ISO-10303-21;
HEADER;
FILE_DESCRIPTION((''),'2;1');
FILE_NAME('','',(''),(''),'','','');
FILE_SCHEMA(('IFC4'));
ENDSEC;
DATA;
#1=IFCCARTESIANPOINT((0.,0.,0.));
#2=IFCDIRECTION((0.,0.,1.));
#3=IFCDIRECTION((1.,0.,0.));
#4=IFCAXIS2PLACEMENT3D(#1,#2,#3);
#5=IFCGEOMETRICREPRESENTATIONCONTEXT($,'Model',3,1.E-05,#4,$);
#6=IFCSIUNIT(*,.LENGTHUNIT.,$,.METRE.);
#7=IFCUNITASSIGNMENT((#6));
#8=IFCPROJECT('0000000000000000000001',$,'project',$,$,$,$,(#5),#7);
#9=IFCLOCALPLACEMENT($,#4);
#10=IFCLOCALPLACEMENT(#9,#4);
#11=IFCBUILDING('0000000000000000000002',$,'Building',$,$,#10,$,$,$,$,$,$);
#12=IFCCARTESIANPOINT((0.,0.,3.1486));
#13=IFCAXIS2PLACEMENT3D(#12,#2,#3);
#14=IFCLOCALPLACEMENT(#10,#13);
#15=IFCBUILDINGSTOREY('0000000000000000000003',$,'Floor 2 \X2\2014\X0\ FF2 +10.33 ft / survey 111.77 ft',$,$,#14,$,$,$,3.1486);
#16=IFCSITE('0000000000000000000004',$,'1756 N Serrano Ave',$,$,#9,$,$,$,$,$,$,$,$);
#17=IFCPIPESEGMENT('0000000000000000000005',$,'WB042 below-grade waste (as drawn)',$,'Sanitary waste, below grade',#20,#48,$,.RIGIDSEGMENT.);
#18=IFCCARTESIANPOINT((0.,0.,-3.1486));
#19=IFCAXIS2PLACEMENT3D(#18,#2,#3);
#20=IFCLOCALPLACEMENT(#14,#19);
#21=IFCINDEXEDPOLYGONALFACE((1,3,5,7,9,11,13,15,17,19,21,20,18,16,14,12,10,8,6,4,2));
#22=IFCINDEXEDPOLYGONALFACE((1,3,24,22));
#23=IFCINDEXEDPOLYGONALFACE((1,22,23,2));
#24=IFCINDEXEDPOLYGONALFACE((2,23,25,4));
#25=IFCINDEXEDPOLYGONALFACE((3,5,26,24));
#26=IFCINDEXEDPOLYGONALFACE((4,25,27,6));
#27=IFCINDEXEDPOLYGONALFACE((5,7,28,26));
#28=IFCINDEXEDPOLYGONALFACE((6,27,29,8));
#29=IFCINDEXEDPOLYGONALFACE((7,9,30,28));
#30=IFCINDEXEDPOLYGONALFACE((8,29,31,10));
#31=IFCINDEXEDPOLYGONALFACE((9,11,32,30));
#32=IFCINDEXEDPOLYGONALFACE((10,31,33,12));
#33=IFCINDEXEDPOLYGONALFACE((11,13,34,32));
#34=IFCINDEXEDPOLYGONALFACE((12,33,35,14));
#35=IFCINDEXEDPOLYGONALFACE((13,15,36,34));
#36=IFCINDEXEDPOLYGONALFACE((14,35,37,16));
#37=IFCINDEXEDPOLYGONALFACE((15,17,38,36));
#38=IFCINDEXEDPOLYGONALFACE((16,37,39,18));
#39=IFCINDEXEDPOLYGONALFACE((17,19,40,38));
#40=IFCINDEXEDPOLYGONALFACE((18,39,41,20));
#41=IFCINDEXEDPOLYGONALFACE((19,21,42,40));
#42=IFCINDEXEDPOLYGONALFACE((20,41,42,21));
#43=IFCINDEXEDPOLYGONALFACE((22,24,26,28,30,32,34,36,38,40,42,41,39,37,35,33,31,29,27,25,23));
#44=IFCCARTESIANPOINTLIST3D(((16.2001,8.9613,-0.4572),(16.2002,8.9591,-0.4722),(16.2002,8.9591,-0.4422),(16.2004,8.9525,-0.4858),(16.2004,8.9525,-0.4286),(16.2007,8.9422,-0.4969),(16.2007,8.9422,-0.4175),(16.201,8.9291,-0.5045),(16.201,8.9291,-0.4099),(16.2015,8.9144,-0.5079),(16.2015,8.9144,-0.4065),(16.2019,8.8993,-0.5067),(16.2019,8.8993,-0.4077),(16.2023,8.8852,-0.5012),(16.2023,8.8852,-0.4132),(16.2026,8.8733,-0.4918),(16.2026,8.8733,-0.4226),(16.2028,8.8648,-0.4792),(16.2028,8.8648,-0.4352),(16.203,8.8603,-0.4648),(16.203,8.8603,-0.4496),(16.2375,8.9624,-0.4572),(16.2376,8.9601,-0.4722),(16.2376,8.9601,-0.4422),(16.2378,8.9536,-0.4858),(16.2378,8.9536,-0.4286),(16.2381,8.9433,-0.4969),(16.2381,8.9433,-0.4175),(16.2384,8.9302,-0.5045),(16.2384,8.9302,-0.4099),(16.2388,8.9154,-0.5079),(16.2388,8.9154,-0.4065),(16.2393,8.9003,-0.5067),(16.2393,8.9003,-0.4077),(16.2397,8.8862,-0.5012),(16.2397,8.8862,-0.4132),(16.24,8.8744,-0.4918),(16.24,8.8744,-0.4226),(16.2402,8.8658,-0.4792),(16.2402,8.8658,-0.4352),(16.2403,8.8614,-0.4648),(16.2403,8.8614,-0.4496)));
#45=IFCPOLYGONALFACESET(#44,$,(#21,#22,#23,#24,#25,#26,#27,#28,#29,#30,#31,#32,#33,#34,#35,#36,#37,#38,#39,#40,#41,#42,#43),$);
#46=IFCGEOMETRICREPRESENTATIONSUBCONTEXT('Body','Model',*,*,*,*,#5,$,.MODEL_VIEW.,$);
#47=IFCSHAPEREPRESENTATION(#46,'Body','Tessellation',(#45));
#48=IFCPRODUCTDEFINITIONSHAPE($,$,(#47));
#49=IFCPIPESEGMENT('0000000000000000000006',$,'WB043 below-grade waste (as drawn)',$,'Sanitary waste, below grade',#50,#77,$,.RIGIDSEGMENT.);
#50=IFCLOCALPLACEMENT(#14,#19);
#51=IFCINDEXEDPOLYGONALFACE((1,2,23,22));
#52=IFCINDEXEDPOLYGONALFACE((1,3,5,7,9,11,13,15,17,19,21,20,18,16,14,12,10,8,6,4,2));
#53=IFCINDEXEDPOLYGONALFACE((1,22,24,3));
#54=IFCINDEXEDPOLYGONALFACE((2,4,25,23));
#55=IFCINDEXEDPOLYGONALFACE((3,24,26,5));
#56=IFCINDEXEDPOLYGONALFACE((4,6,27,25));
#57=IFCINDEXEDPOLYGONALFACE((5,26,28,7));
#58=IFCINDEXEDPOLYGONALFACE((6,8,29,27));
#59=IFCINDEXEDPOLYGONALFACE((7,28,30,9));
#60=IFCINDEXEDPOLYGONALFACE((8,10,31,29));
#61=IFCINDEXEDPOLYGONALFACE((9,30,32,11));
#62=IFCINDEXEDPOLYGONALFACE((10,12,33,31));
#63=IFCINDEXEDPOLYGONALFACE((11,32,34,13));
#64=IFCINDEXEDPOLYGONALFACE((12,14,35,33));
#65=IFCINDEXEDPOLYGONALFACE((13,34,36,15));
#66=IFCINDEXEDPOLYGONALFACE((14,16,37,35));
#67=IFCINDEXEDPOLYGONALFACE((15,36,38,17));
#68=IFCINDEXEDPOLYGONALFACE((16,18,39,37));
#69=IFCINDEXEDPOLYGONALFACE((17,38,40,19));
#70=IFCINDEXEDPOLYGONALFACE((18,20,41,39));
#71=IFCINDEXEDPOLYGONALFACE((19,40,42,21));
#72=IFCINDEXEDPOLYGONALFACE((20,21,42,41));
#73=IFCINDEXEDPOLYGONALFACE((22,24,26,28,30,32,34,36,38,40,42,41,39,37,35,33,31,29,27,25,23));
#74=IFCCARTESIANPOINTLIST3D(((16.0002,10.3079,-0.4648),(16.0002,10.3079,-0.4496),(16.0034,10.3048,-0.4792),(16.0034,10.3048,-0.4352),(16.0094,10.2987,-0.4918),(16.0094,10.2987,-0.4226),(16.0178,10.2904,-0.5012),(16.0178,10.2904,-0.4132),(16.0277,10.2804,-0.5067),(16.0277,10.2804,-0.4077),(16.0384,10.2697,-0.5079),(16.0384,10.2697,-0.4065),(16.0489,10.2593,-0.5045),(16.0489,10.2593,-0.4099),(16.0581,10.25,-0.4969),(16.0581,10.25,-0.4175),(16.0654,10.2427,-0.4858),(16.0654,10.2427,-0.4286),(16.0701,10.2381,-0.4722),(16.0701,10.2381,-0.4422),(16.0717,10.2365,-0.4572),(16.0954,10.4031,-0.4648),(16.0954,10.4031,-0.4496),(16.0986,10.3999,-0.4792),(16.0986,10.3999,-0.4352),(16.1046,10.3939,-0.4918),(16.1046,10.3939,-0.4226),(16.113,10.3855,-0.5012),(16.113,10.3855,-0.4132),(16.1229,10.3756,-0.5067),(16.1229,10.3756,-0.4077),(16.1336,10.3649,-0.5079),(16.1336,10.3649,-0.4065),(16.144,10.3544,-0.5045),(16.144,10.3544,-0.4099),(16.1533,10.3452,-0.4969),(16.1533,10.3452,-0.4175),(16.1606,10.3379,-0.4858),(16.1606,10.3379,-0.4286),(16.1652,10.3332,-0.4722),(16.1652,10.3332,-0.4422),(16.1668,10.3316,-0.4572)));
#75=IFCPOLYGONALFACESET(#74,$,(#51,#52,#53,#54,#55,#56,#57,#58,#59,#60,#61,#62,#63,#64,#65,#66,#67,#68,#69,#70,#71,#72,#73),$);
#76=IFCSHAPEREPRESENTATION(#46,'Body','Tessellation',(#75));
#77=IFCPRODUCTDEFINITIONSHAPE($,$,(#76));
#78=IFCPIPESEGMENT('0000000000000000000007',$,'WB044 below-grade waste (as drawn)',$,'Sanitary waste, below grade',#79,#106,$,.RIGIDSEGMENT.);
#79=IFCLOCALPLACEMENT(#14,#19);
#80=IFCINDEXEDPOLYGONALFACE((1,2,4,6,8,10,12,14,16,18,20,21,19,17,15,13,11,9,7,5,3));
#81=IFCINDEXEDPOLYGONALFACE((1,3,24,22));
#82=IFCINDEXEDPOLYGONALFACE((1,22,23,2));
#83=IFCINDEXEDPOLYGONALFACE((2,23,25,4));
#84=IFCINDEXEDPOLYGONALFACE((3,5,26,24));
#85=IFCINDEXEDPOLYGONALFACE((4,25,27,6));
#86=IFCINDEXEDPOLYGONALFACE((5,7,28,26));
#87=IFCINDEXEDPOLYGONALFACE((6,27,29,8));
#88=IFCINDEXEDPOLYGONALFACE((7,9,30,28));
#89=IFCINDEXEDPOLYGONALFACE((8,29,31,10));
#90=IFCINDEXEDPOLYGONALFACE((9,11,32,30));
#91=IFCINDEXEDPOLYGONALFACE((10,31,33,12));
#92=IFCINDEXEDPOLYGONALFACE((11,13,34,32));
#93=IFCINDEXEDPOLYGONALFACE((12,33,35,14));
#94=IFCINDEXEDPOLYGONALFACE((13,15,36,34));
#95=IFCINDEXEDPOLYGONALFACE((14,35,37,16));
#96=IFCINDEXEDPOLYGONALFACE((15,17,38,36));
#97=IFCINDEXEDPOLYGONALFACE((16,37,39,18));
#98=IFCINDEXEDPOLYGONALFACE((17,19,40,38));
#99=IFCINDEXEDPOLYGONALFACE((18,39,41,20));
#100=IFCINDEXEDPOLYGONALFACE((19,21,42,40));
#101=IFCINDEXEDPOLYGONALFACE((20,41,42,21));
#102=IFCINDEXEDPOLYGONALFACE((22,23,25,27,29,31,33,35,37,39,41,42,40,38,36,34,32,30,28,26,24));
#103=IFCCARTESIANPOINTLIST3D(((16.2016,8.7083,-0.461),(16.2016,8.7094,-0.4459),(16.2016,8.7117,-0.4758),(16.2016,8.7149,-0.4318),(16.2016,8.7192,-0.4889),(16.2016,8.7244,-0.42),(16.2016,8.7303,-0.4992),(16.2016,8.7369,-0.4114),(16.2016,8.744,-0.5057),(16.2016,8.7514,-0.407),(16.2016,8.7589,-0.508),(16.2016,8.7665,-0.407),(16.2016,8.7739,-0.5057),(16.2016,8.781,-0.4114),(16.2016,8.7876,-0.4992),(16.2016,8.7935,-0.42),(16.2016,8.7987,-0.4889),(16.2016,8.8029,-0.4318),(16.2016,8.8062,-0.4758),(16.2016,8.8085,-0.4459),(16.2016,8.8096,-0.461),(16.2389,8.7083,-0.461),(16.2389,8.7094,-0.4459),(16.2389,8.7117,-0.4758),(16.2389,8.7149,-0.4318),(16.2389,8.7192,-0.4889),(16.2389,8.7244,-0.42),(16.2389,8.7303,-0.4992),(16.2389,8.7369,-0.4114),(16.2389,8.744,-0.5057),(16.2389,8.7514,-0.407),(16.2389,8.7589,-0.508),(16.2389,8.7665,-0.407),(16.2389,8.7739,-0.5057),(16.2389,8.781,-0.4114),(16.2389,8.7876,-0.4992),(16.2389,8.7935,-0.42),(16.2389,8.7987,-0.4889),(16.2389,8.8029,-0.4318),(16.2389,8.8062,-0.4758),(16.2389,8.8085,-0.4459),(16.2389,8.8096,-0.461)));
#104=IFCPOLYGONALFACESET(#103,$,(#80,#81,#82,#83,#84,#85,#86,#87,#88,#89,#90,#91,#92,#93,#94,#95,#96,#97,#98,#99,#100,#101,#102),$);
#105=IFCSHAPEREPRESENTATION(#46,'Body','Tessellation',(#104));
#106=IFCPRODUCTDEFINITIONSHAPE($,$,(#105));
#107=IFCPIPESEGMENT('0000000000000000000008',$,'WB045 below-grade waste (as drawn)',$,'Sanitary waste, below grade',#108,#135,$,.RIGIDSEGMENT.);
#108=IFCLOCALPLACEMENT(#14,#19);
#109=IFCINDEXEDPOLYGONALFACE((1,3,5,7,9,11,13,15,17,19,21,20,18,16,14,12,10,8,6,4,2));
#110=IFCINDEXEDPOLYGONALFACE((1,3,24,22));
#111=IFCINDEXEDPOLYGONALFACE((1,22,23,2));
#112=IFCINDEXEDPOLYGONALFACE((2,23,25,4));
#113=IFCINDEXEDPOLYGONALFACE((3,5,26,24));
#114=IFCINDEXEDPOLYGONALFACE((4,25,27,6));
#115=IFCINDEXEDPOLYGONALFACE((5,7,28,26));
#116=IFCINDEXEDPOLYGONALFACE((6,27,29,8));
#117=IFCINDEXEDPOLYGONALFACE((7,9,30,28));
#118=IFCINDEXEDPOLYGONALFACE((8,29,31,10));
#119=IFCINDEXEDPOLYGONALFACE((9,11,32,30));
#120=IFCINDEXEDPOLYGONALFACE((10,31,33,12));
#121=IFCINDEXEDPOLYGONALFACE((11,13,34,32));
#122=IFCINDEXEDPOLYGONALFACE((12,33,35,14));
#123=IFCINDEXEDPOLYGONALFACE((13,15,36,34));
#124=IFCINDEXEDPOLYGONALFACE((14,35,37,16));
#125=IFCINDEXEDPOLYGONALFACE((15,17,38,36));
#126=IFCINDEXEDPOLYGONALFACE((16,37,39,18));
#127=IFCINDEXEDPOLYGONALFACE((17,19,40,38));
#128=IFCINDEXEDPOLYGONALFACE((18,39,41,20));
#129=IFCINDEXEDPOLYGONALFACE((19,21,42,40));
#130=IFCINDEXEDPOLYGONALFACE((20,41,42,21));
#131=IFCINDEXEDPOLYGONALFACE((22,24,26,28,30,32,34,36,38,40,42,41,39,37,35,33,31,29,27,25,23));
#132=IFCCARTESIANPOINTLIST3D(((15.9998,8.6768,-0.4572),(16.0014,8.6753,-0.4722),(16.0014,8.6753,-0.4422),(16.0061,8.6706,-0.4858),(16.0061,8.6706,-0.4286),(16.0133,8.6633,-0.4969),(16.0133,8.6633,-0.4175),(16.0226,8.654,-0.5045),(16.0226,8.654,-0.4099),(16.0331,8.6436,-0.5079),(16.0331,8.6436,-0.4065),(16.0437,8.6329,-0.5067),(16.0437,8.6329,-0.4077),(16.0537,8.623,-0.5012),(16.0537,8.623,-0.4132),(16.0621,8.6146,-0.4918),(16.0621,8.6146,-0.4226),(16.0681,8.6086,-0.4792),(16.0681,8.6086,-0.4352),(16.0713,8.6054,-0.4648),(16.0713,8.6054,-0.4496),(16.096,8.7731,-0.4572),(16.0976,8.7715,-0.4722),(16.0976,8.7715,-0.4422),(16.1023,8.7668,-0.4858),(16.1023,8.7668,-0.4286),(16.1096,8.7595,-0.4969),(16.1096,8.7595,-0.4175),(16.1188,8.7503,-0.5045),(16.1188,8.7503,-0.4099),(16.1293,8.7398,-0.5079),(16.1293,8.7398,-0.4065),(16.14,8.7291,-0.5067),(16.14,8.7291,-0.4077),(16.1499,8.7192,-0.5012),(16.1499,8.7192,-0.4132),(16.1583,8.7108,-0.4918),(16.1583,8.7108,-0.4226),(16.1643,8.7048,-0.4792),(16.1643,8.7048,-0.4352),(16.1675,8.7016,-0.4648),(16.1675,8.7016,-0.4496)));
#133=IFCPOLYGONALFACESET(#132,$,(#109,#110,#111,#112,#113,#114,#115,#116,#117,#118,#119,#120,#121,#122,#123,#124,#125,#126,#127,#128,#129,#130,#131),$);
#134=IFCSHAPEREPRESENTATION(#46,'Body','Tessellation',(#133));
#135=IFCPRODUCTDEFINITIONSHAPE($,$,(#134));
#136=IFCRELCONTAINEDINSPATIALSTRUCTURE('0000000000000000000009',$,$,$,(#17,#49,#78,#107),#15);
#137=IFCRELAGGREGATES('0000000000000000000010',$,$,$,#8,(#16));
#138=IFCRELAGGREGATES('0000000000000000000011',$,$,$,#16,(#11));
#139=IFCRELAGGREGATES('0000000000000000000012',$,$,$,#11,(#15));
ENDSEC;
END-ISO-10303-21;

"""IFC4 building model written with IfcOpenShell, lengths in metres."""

from ifc_helpers import new_model, entity, si_unit, frame, origin_with_axes, place, context, subcontext, project, spatial, element, save


model = new_model("IFC4")

# Units and contexts
model_context = context("Model", 3, precision=1e-05, world=origin_with_axes())
body_context = subcontext(model_context, "Body", "Model", "MODEL_VIEW")
ifc_project = project(units=[si_unit("LENGTHUNIT", "METRE")], contexts=[model_context])

# Site, building, storey
site_placement = place(None, origin_with_axes())
site = spatial("IfcSite", under=ifc_project, at=site_placement, Name="1756 N Serrano Ave")
building_placement = place(site_placement, origin_with_axes())
building = spatial("IfcBuilding", under=site, at=building_placement, Name="Building")
storey_placement = place(building_placement, frame((0.0, 0.0, 3.1486), z_axis=(0.0, 0.0, 1.0), x_axis=(1.0, 0.0, 0.0)))
storey = spatial("IfcBuildingStorey", under=building, at=storey_placement, Name="Floor 2 — FF2 +10.33 ft / survey 111.77 ft", Elevation=3.1486)

# Pipe segments
pipe_segment_1_placement = place(storey_placement, frame((0.0, 0.0, -3.1486), z_axis=(0.0, 0.0, 1.0), x_axis=(1.0, 0.0, 0.0)))
element("IfcPipeSegment", 1, at=pipe_segment_1_placement, inside=storey, Name="WB042 below-grade waste (as drawn)", ObjectType="Sanitary waste, below grade", PredefinedType="RIGIDSEGMENT", context=body_context, shape_type="AdvancedSweptSolid", body=[
    entity("IfcSweptDiskSolid", entity("IfcPolyline", [entity("IfcCartesianPoint", [16.2016, 8.9106, -0.4572]), entity("IfcCartesianPoint", [16.2389, 8.9116, -0.4572])]), 0.0508),
])
pipe_segment_2_placement = place(storey_placement, frame((0.0, 0.0, -3.1486), z_axis=(0.0, 0.0, 1.0), x_axis=(1.0, 0.0, 0.0)))
element("IfcPipeSegment", 2, at=pipe_segment_2_placement, inside=storey, Name="WB043 below-grade waste (as drawn)", ObjectType="Sanitary waste, below grade", PredefinedType="RIGIDSEGMENT", context=body_context, shape_type="AdvancedSweptSolid", body=[
    entity("IfcSweptDiskSolid", entity("IfcPolyline", [entity("IfcCartesianPoint", [16.1309, 10.3676, -0.4572]), entity("IfcCartesianPoint", [16.0357, 10.2724, -0.4572])]), 0.0508),
])
pipe_segment_3_placement = place(storey_placement, frame((0.0, 0.0, -3.1486), z_axis=(0.0, 0.0, 1.0), x_axis=(1.0, 0.0, 0.0)))
element("IfcPipeSegment", 3, at=pipe_segment_3_placement, inside=storey, Name="WB044 below-grade waste (as drawn)", ObjectType="Sanitary waste, below grade", PredefinedType="RIGIDSEGMENT", context=body_context, shape_type="AdvancedSweptSolid", body=[
    entity("IfcSweptDiskSolid", entity("IfcPolyline", [entity("IfcCartesianPoint", [16.2389, 8.7589, -0.4572]), entity("IfcCartesianPoint", [16.2016, 8.7589, -0.4572])]), 0.0508),
])
pipe_segment_4_placement = place(storey_placement, frame((0.0, 0.0, -3.1486), z_axis=(0.0, 0.0, 1.0), x_axis=(1.0, 0.0, 0.0)))
element("IfcPipeSegment", 4, at=pipe_segment_4_placement, inside=storey, Name="WB045 below-grade waste (as drawn)", ObjectType="Sanitary waste, below grade", PredefinedType="RIGIDSEGMENT", context=body_context, shape_type="AdvancedSweptSolid", body=[
    entity("IfcSweptDiskSolid", entity("IfcPolyline", [entity("IfcCartesianPoint", [16.0357, 8.6409, -0.4572]), entity("IfcCartesianPoint", [16.132, 8.7371, -0.4572])]), 0.0508),
])

save(model, "model.ifc")
